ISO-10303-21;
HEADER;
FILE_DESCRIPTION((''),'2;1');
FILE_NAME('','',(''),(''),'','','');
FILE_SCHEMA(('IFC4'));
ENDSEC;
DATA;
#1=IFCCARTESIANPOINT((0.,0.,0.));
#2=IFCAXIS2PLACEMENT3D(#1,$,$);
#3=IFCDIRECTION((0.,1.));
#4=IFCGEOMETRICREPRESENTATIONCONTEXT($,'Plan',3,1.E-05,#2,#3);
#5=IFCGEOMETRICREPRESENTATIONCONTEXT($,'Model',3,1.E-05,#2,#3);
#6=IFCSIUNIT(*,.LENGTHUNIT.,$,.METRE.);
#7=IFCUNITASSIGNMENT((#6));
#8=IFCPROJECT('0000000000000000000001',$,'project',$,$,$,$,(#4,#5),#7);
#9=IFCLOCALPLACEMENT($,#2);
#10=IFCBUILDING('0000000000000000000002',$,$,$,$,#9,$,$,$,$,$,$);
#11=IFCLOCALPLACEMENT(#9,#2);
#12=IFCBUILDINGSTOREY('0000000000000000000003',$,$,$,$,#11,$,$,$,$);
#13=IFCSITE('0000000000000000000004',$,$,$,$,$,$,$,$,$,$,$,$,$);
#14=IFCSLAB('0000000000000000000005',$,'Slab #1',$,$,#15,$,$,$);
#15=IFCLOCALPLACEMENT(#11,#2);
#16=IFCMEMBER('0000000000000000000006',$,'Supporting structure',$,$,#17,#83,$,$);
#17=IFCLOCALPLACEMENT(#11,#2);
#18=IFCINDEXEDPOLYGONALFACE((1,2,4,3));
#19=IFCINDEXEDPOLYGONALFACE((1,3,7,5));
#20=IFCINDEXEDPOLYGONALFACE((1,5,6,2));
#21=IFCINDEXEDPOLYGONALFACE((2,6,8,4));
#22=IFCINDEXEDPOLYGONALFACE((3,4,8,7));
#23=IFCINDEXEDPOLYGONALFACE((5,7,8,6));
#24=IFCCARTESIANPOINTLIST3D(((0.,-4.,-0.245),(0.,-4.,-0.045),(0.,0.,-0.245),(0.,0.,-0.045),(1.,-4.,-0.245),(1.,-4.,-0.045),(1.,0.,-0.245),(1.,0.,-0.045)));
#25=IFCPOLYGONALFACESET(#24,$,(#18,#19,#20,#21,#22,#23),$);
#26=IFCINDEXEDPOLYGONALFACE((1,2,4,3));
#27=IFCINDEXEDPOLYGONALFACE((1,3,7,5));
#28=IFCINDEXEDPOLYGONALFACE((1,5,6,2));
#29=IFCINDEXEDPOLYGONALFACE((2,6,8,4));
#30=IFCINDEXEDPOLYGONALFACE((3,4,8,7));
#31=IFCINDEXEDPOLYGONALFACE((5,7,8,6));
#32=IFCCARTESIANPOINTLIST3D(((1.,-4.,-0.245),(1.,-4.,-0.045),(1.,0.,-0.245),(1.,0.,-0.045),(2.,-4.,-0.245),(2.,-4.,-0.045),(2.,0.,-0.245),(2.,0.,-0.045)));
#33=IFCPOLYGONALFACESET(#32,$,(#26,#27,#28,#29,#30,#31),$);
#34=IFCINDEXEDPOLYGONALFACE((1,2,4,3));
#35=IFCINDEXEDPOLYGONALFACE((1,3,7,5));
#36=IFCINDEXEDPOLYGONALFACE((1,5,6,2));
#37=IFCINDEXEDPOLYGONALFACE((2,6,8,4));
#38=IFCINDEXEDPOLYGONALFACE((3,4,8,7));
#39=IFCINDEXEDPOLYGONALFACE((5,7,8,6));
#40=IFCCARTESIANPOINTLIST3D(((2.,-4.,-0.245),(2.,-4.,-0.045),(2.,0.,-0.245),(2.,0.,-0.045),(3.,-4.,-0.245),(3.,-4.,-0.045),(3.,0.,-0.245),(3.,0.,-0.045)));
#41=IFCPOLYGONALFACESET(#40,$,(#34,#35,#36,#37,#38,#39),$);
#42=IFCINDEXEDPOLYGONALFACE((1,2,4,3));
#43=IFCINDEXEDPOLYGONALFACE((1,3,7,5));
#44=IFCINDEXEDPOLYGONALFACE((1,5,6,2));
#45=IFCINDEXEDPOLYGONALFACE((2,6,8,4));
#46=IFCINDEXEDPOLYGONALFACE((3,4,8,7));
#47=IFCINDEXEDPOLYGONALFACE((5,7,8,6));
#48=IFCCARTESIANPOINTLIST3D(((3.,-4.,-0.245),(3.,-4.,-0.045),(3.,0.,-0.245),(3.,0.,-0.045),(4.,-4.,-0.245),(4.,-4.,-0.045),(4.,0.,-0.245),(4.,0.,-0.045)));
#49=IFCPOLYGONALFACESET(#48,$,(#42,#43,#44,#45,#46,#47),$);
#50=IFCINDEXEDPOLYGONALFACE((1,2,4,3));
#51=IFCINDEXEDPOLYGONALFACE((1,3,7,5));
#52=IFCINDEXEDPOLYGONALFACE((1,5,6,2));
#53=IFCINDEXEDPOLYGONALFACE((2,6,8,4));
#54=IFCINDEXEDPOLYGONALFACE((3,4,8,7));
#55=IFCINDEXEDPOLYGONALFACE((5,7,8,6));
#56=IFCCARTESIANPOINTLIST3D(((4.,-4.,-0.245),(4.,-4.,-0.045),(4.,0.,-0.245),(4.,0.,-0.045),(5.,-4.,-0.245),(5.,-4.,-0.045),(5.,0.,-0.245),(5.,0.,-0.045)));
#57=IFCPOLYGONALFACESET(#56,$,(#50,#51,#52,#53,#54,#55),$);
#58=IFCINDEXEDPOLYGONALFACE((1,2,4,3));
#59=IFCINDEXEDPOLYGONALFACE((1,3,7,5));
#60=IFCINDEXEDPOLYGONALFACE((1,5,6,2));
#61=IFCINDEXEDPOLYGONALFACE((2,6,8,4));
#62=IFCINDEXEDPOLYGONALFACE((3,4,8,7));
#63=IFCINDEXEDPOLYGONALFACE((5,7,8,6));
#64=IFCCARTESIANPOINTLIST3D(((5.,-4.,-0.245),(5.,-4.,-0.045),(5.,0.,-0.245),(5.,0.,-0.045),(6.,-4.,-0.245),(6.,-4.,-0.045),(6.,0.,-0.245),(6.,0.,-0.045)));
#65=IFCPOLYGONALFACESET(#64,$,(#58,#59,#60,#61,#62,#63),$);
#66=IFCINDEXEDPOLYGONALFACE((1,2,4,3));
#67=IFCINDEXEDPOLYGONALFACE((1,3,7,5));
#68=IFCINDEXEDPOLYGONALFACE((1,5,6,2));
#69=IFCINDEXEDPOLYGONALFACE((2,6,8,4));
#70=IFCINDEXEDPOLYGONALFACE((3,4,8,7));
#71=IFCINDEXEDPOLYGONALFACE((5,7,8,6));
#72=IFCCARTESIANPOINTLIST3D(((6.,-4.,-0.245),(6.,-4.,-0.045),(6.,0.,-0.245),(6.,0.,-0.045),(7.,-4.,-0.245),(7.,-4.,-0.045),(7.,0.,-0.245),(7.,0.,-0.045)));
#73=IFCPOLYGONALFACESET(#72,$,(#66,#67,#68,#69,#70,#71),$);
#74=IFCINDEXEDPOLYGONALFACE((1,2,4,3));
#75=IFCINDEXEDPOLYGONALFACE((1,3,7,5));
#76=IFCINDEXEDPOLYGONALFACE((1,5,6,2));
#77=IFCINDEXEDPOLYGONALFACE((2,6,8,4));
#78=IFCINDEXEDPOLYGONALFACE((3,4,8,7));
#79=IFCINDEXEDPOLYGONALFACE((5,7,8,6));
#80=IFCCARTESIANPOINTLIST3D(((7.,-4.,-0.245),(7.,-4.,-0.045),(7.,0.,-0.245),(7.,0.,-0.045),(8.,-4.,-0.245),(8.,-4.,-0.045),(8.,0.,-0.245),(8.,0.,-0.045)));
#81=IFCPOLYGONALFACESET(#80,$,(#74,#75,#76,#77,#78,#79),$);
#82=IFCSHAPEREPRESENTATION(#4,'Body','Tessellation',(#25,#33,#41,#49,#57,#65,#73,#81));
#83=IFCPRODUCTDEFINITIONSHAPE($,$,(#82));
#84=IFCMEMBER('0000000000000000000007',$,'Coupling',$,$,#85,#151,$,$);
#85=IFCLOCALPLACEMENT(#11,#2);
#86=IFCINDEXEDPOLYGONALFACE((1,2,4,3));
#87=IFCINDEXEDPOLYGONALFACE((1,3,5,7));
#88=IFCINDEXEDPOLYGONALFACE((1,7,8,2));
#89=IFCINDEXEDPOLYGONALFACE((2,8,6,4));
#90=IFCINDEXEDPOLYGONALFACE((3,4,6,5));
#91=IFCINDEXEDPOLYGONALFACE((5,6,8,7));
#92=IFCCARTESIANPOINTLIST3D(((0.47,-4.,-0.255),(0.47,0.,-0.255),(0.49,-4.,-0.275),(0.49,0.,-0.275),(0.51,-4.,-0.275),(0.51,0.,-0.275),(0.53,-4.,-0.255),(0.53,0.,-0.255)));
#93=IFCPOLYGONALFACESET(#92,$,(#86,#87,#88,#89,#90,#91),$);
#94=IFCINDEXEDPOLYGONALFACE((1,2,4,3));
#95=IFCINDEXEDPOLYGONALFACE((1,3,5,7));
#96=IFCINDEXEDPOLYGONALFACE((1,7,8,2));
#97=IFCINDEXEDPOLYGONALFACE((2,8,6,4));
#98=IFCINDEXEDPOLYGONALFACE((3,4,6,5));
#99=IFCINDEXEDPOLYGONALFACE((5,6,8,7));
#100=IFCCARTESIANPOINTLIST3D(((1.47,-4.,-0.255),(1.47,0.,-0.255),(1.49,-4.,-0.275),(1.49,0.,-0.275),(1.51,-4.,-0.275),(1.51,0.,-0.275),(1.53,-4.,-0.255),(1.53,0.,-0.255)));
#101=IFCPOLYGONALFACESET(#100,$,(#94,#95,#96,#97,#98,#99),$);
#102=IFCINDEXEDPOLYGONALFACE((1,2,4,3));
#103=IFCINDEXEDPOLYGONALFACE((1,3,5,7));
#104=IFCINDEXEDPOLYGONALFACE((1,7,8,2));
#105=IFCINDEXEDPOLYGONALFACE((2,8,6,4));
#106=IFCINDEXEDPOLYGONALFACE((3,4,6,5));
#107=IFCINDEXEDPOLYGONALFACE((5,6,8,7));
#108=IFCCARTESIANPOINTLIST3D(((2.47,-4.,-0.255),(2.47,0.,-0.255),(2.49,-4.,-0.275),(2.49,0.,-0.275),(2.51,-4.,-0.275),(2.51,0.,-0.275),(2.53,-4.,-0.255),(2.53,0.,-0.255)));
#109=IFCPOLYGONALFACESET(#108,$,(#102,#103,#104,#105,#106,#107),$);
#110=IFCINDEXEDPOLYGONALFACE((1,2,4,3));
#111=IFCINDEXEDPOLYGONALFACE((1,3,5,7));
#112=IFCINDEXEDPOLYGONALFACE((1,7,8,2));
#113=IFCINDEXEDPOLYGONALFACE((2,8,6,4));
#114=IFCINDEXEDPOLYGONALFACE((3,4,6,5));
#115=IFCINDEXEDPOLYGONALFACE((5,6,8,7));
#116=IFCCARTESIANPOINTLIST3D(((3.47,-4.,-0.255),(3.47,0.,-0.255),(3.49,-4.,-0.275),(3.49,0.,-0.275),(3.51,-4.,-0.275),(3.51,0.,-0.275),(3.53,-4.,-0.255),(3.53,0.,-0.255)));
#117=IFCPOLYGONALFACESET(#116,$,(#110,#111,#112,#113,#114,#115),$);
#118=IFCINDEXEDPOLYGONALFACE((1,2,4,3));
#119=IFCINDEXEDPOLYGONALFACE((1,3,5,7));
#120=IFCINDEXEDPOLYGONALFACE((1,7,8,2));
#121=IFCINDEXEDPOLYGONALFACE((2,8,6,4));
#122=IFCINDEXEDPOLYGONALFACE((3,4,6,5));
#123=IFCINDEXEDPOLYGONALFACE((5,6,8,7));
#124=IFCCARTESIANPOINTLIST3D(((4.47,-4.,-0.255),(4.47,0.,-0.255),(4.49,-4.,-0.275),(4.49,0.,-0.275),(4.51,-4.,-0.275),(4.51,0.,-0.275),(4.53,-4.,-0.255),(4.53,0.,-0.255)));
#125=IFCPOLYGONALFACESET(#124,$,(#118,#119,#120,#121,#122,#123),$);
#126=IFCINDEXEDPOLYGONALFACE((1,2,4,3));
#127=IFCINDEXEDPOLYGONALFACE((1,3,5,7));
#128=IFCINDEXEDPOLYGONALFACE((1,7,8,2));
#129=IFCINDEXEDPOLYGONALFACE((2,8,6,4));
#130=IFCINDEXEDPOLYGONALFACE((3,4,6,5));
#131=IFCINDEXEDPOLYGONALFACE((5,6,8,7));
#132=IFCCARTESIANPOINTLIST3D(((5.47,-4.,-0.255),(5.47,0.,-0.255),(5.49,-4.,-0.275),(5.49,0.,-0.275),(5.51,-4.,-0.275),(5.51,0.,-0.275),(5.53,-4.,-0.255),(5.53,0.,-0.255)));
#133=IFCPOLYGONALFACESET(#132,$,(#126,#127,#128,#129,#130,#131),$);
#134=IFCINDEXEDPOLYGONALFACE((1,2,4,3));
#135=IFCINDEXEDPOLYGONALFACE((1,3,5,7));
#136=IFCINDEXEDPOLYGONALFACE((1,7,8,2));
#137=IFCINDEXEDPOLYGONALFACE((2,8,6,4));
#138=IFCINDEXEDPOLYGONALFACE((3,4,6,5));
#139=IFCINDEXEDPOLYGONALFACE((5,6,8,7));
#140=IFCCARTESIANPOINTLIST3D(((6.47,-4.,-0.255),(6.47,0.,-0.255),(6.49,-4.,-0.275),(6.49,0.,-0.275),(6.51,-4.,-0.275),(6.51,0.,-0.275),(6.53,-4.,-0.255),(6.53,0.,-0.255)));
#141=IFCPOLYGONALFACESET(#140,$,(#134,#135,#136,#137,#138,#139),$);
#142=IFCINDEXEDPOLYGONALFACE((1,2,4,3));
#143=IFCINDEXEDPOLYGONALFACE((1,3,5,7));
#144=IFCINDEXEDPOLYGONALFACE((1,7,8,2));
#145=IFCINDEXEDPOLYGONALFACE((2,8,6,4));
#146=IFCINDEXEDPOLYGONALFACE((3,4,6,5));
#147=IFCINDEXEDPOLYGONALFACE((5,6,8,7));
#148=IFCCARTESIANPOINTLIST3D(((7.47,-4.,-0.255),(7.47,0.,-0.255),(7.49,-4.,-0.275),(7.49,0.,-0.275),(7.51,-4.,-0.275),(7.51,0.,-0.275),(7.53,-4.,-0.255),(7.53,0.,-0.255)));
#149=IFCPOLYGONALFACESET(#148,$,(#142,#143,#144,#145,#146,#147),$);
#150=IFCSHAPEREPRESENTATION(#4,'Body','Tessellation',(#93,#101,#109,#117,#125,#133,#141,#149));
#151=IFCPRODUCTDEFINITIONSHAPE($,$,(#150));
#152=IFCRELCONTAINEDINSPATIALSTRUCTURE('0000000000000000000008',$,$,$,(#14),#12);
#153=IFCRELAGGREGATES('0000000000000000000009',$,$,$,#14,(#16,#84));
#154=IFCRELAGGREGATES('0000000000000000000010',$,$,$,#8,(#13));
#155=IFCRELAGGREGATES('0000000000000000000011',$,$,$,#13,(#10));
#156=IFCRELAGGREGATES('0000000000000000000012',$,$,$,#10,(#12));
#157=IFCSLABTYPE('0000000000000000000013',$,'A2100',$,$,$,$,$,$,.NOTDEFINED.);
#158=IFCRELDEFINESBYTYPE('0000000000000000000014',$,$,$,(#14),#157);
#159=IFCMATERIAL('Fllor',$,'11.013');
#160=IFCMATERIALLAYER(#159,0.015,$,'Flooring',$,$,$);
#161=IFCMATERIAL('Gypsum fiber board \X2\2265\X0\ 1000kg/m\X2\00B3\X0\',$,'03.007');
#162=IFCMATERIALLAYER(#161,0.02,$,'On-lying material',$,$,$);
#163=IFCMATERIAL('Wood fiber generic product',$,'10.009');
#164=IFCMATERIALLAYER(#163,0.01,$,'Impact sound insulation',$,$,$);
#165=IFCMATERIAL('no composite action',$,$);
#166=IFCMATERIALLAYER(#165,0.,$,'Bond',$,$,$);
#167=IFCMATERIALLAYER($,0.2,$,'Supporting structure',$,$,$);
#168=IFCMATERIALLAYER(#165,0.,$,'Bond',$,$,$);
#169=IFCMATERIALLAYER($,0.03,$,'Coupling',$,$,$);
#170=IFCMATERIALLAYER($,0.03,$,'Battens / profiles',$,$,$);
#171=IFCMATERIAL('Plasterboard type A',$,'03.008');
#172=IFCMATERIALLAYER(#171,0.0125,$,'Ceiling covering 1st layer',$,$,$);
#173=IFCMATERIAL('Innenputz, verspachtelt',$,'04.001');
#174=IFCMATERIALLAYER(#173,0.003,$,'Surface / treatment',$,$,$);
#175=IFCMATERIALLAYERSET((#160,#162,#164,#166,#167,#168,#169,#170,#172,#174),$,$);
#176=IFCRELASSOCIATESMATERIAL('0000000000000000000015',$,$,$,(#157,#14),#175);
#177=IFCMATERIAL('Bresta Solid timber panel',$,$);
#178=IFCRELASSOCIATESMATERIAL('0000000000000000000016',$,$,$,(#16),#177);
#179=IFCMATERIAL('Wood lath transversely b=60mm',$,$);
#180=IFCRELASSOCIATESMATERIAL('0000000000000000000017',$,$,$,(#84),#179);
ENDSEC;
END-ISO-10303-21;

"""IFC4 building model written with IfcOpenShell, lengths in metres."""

from ifc_helpers import new_model, si_unit, direction, frame, frame_2d, origin, place, context, project, spatial, polyline, rectangle, outline, extrude, material, layer, layer_set, type_object, element, aggregate, save


model = new_model("IFC4")

# Units and contexts
plan_context = context("Plan", 3, precision=1e-05, world=origin(), true_north=direction((0.0, 1.0)))
model_context = context("Model", 3, precision=1e-05, world=origin(), true_north=direction((0.0, 1.0)))
ifc_project = project(units=[si_unit("LENGTHUNIT", "METRE")], contexts=[plan_context, model_context])

# Site, building, storey
site = spatial("IfcSite", under=ifc_project)
building_placement = place(None, origin())
building = spatial("IfcBuilding", under=site, at=building_placement)
storey_placement = place(building_placement, origin())
storey = spatial("IfcBuildingStorey", under=building, at=storey_placement)

# Slab, members
ifc_material_1 = material(Name="Fllor", Category="11.013")
ifc_layer_1 = layer(ifc_material_1, 0.015, Name="Flooring")
ifc_material_2 = material(Name="Gypsum fiber board ≥ 1000kg/m³", Category="03.007")
ifc_layer_2 = layer(ifc_material_2, 0.02, Name="On-lying material")
ifc_material_3 = material(Name="Wood fiber generic product", Category="10.009")
ifc_layer_3 = layer(ifc_material_3, 0.01, Name="Impact sound insulation")
ifc_material_4 = material(Name="no composite action")
ifc_layer_4 = layer(ifc_material_4, 0.0, Name="Bond")
ifc_layer_5 = layer(None, 0.2, Name="Supporting structure")
ifc_layer_6 = layer(ifc_material_4, 0.0, Name="Bond")
ifc_layer_7 = layer(None, 0.03, Name="Coupling")
ifc_layer_8 = layer(None, 0.03, Name="Battens / profiles")
ifc_material_5 = material(Name="Plasterboard type A", Category="03.008")
ifc_layer_9 = layer(ifc_material_5, 0.0125, Name="Ceiling covering 1st layer")
ifc_material_6 = material(Name="Innenputz, verspachtelt", Category="04.001")
ifc_layer_10 = layer(ifc_material_6, 0.003, Name="Surface / treatment")
ifc_layer_set = layer_set([ifc_layer_1, ifc_layer_2, ifc_layer_3, ifc_layer_4, ifc_layer_5, ifc_layer_6, ifc_layer_7, ifc_layer_8, ifc_layer_9, ifc_layer_10])
slab_type = type_object("IfcSlabType", Name="A2100", PredefinedType="NOTDEFINED", material=ifc_layer_set)
slab_placement = place(None, frame((0.0, 0.0, 0.0), z_axis=(0.0, 0.0, -1.0), x_axis=(1.0, 0.0, 0.0)))
slab = element("IfcSlab", 1, at=slab_placement, inside=storey, type_object=slab_type, material=ifc_layer_set, Name="Slab #1")
ifc_material_7 = material(Name="Bresta Solid timber panel")
member_1_placement = place(slab_placement, origin())
member_1 = element("IfcMember", 2, at=member_1_placement, material=ifc_material_7, Name="Supporting structure", context=plan_context, shape_type="SweptSolid", body=[
    extrude(rectangle(XDim=1.0, YDim=0.2, at=frame_2d((0.5, 0.1), x_axis=(1.0, 0.0))), frame((0.0, 4.0, 0.045), z_axis=(0.0, -1.0, 0.0), x_axis=(1.0, 0.0, 0.0)), (0.0, 0.0, 1.0), 4.0),
    extrude(rectangle(XDim=1.0, YDim=0.2, at=frame_2d((0.5, 0.1), x_axis=(1.0, 0.0))), frame((1.0, 4.0, 0.045), z_axis=(0.0, -1.0, 0.0), x_axis=(1.0, 0.0, 0.0)), (0.0, 0.0, 1.0), 4.0),
    extrude(rectangle(XDim=1.0, YDim=0.2, at=frame_2d((0.5, 0.1), x_axis=(1.0, 0.0))), frame((2.0, 4.0, 0.045), z_axis=(0.0, -1.0, 0.0), x_axis=(1.0, 0.0, 0.0)), (0.0, 0.0, 1.0), 4.0),
    extrude(rectangle(XDim=1.0, YDim=0.2, at=frame_2d((0.5, 0.1), x_axis=(1.0, 0.0))), frame((3.0, 4.0, 0.045), z_axis=(0.0, -1.0, 0.0), x_axis=(1.0, 0.0, 0.0)), (0.0, 0.0, 1.0), 4.0),
    extrude(rectangle(XDim=1.0, YDim=0.2, at=frame_2d((0.5, 0.1), x_axis=(1.0, 0.0))), frame((4.0, 4.0, 0.045), z_axis=(0.0, -1.0, 0.0), x_axis=(1.0, 0.0, 0.0)), (0.0, 0.0, 1.0), 4.0),
    extrude(rectangle(XDim=1.0, YDim=0.2, at=frame_2d((0.5, 0.1), x_axis=(1.0, 0.0))), frame((5.0, 4.0, 0.045), z_axis=(0.0, -1.0, 0.0), x_axis=(1.0, 0.0, 0.0)), (0.0, 0.0, 1.0), 4.0),
    extrude(rectangle(XDim=1.0, YDim=0.2, at=frame_2d((0.5, 0.1), x_axis=(1.0, 0.0))), frame((6.0, 4.0, 0.045), z_axis=(0.0, -1.0, 0.0), x_axis=(1.0, 0.0, 0.0)), (0.0, 0.0, 1.0), 4.0),
    extrude(rectangle(XDim=1.0, YDim=0.2, at=frame_2d((0.5, 0.1), x_axis=(1.0, 0.0))), frame((7.0, 4.0, 0.045), z_axis=(0.0, -1.0, 0.0), x_axis=(1.0, 0.0, 0.0)), (0.0, 0.0, 1.0), 4.0),
])
ifc_material_8 = material(Name="Wood lath transversely b=60mm")
member_2_placement = place(slab_placement, origin())
member_2 = element("IfcMember", 3, at=member_2_placement, material=ifc_material_8, Name="Coupling", context=plan_context, shape_type="SweptSolid", body=[
    extrude(outline(polyline([(0.0, 0.0), (0.06, 0.0), (0.04, 0.02), (0.02, 0.02), (0.0, 0.0)])), frame((0.47, 4.0, 0.255), z_axis=(0.0, -1.0, 0.0), x_axis=(1.0, 0.0, 0.0)), (0.0, 0.0, 1.0), 4.0),
    extrude(outline(polyline([(0.0, 0.0), (0.06, 0.0), (0.04, 0.02), (0.02, 0.02), (0.0, 0.0)])), frame((1.47, 4.0, 0.255), z_axis=(0.0, -1.0, 0.0), x_axis=(1.0, 0.0, 0.0)), (0.0, 0.0, 1.0), 4.0),
    extrude(outline(polyline([(0.0, 0.0), (0.06, 0.0), (0.04, 0.02), (0.02, 0.02), (0.0, 0.0)])), frame((2.47, 4.0, 0.255), z_axis=(0.0, -1.0, 0.0), x_axis=(1.0, 0.0, 0.0)), (0.0, 0.0, 1.0), 4.0),
    extrude(outline(polyline([(0.0, 0.0), (0.06, 0.0), (0.04, 0.02), (0.02, 0.02), (0.0, 0.0)])), frame((3.47, 4.0, 0.255), z_axis=(0.0, -1.0, 0.0), x_axis=(1.0, 0.0, 0.0)), (0.0, 0.0, 1.0), 4.0),
    extrude(outline(polyline([(0.0, 0.0), (0.06, 0.0), (0.04, 0.02), (0.02, 0.02), (0.0, 0.0)])), frame((4.47, 4.0, 0.255), z_axis=(0.0, -1.0, 0.0), x_axis=(1.0, 0.0, 0.0)), (0.0, 0.0, 1.0), 4.0),
    extrude(outline(polyline([(0.0, 0.0), (0.06, 0.0), (0.04, 0.02), (0.02, 0.02), (0.0, 0.0)])), frame((5.47, 4.0, 0.255), z_axis=(0.0, -1.0, 0.0), x_axis=(1.0, 0.0, 0.0)), (0.0, 0.0, 1.0), 4.0),
    extrude(outline(polyline([(0.0, 0.0), (0.06, 0.0), (0.04, 0.02), (0.02, 0.02), (0.0, 0.0)])), frame((6.47, 4.0, 0.255), z_axis=(0.0, -1.0, 0.0), x_axis=(1.0, 0.0, 0.0)), (0.0, 0.0, 1.0), 4.0),
    extrude(outline(polyline([(0.0, 0.0), (0.06, 0.0), (0.04, 0.02), (0.02, 0.02), (0.0, 0.0)])), frame((7.47, 4.0, 0.255), z_axis=(0.0, -1.0, 0.0), x_axis=(1.0, 0.0, 0.0)), (0.0, 0.0, 1.0), 4.0),
])
aggregate(slab, [member_1, member_2])

save(model, "model.ifc")
